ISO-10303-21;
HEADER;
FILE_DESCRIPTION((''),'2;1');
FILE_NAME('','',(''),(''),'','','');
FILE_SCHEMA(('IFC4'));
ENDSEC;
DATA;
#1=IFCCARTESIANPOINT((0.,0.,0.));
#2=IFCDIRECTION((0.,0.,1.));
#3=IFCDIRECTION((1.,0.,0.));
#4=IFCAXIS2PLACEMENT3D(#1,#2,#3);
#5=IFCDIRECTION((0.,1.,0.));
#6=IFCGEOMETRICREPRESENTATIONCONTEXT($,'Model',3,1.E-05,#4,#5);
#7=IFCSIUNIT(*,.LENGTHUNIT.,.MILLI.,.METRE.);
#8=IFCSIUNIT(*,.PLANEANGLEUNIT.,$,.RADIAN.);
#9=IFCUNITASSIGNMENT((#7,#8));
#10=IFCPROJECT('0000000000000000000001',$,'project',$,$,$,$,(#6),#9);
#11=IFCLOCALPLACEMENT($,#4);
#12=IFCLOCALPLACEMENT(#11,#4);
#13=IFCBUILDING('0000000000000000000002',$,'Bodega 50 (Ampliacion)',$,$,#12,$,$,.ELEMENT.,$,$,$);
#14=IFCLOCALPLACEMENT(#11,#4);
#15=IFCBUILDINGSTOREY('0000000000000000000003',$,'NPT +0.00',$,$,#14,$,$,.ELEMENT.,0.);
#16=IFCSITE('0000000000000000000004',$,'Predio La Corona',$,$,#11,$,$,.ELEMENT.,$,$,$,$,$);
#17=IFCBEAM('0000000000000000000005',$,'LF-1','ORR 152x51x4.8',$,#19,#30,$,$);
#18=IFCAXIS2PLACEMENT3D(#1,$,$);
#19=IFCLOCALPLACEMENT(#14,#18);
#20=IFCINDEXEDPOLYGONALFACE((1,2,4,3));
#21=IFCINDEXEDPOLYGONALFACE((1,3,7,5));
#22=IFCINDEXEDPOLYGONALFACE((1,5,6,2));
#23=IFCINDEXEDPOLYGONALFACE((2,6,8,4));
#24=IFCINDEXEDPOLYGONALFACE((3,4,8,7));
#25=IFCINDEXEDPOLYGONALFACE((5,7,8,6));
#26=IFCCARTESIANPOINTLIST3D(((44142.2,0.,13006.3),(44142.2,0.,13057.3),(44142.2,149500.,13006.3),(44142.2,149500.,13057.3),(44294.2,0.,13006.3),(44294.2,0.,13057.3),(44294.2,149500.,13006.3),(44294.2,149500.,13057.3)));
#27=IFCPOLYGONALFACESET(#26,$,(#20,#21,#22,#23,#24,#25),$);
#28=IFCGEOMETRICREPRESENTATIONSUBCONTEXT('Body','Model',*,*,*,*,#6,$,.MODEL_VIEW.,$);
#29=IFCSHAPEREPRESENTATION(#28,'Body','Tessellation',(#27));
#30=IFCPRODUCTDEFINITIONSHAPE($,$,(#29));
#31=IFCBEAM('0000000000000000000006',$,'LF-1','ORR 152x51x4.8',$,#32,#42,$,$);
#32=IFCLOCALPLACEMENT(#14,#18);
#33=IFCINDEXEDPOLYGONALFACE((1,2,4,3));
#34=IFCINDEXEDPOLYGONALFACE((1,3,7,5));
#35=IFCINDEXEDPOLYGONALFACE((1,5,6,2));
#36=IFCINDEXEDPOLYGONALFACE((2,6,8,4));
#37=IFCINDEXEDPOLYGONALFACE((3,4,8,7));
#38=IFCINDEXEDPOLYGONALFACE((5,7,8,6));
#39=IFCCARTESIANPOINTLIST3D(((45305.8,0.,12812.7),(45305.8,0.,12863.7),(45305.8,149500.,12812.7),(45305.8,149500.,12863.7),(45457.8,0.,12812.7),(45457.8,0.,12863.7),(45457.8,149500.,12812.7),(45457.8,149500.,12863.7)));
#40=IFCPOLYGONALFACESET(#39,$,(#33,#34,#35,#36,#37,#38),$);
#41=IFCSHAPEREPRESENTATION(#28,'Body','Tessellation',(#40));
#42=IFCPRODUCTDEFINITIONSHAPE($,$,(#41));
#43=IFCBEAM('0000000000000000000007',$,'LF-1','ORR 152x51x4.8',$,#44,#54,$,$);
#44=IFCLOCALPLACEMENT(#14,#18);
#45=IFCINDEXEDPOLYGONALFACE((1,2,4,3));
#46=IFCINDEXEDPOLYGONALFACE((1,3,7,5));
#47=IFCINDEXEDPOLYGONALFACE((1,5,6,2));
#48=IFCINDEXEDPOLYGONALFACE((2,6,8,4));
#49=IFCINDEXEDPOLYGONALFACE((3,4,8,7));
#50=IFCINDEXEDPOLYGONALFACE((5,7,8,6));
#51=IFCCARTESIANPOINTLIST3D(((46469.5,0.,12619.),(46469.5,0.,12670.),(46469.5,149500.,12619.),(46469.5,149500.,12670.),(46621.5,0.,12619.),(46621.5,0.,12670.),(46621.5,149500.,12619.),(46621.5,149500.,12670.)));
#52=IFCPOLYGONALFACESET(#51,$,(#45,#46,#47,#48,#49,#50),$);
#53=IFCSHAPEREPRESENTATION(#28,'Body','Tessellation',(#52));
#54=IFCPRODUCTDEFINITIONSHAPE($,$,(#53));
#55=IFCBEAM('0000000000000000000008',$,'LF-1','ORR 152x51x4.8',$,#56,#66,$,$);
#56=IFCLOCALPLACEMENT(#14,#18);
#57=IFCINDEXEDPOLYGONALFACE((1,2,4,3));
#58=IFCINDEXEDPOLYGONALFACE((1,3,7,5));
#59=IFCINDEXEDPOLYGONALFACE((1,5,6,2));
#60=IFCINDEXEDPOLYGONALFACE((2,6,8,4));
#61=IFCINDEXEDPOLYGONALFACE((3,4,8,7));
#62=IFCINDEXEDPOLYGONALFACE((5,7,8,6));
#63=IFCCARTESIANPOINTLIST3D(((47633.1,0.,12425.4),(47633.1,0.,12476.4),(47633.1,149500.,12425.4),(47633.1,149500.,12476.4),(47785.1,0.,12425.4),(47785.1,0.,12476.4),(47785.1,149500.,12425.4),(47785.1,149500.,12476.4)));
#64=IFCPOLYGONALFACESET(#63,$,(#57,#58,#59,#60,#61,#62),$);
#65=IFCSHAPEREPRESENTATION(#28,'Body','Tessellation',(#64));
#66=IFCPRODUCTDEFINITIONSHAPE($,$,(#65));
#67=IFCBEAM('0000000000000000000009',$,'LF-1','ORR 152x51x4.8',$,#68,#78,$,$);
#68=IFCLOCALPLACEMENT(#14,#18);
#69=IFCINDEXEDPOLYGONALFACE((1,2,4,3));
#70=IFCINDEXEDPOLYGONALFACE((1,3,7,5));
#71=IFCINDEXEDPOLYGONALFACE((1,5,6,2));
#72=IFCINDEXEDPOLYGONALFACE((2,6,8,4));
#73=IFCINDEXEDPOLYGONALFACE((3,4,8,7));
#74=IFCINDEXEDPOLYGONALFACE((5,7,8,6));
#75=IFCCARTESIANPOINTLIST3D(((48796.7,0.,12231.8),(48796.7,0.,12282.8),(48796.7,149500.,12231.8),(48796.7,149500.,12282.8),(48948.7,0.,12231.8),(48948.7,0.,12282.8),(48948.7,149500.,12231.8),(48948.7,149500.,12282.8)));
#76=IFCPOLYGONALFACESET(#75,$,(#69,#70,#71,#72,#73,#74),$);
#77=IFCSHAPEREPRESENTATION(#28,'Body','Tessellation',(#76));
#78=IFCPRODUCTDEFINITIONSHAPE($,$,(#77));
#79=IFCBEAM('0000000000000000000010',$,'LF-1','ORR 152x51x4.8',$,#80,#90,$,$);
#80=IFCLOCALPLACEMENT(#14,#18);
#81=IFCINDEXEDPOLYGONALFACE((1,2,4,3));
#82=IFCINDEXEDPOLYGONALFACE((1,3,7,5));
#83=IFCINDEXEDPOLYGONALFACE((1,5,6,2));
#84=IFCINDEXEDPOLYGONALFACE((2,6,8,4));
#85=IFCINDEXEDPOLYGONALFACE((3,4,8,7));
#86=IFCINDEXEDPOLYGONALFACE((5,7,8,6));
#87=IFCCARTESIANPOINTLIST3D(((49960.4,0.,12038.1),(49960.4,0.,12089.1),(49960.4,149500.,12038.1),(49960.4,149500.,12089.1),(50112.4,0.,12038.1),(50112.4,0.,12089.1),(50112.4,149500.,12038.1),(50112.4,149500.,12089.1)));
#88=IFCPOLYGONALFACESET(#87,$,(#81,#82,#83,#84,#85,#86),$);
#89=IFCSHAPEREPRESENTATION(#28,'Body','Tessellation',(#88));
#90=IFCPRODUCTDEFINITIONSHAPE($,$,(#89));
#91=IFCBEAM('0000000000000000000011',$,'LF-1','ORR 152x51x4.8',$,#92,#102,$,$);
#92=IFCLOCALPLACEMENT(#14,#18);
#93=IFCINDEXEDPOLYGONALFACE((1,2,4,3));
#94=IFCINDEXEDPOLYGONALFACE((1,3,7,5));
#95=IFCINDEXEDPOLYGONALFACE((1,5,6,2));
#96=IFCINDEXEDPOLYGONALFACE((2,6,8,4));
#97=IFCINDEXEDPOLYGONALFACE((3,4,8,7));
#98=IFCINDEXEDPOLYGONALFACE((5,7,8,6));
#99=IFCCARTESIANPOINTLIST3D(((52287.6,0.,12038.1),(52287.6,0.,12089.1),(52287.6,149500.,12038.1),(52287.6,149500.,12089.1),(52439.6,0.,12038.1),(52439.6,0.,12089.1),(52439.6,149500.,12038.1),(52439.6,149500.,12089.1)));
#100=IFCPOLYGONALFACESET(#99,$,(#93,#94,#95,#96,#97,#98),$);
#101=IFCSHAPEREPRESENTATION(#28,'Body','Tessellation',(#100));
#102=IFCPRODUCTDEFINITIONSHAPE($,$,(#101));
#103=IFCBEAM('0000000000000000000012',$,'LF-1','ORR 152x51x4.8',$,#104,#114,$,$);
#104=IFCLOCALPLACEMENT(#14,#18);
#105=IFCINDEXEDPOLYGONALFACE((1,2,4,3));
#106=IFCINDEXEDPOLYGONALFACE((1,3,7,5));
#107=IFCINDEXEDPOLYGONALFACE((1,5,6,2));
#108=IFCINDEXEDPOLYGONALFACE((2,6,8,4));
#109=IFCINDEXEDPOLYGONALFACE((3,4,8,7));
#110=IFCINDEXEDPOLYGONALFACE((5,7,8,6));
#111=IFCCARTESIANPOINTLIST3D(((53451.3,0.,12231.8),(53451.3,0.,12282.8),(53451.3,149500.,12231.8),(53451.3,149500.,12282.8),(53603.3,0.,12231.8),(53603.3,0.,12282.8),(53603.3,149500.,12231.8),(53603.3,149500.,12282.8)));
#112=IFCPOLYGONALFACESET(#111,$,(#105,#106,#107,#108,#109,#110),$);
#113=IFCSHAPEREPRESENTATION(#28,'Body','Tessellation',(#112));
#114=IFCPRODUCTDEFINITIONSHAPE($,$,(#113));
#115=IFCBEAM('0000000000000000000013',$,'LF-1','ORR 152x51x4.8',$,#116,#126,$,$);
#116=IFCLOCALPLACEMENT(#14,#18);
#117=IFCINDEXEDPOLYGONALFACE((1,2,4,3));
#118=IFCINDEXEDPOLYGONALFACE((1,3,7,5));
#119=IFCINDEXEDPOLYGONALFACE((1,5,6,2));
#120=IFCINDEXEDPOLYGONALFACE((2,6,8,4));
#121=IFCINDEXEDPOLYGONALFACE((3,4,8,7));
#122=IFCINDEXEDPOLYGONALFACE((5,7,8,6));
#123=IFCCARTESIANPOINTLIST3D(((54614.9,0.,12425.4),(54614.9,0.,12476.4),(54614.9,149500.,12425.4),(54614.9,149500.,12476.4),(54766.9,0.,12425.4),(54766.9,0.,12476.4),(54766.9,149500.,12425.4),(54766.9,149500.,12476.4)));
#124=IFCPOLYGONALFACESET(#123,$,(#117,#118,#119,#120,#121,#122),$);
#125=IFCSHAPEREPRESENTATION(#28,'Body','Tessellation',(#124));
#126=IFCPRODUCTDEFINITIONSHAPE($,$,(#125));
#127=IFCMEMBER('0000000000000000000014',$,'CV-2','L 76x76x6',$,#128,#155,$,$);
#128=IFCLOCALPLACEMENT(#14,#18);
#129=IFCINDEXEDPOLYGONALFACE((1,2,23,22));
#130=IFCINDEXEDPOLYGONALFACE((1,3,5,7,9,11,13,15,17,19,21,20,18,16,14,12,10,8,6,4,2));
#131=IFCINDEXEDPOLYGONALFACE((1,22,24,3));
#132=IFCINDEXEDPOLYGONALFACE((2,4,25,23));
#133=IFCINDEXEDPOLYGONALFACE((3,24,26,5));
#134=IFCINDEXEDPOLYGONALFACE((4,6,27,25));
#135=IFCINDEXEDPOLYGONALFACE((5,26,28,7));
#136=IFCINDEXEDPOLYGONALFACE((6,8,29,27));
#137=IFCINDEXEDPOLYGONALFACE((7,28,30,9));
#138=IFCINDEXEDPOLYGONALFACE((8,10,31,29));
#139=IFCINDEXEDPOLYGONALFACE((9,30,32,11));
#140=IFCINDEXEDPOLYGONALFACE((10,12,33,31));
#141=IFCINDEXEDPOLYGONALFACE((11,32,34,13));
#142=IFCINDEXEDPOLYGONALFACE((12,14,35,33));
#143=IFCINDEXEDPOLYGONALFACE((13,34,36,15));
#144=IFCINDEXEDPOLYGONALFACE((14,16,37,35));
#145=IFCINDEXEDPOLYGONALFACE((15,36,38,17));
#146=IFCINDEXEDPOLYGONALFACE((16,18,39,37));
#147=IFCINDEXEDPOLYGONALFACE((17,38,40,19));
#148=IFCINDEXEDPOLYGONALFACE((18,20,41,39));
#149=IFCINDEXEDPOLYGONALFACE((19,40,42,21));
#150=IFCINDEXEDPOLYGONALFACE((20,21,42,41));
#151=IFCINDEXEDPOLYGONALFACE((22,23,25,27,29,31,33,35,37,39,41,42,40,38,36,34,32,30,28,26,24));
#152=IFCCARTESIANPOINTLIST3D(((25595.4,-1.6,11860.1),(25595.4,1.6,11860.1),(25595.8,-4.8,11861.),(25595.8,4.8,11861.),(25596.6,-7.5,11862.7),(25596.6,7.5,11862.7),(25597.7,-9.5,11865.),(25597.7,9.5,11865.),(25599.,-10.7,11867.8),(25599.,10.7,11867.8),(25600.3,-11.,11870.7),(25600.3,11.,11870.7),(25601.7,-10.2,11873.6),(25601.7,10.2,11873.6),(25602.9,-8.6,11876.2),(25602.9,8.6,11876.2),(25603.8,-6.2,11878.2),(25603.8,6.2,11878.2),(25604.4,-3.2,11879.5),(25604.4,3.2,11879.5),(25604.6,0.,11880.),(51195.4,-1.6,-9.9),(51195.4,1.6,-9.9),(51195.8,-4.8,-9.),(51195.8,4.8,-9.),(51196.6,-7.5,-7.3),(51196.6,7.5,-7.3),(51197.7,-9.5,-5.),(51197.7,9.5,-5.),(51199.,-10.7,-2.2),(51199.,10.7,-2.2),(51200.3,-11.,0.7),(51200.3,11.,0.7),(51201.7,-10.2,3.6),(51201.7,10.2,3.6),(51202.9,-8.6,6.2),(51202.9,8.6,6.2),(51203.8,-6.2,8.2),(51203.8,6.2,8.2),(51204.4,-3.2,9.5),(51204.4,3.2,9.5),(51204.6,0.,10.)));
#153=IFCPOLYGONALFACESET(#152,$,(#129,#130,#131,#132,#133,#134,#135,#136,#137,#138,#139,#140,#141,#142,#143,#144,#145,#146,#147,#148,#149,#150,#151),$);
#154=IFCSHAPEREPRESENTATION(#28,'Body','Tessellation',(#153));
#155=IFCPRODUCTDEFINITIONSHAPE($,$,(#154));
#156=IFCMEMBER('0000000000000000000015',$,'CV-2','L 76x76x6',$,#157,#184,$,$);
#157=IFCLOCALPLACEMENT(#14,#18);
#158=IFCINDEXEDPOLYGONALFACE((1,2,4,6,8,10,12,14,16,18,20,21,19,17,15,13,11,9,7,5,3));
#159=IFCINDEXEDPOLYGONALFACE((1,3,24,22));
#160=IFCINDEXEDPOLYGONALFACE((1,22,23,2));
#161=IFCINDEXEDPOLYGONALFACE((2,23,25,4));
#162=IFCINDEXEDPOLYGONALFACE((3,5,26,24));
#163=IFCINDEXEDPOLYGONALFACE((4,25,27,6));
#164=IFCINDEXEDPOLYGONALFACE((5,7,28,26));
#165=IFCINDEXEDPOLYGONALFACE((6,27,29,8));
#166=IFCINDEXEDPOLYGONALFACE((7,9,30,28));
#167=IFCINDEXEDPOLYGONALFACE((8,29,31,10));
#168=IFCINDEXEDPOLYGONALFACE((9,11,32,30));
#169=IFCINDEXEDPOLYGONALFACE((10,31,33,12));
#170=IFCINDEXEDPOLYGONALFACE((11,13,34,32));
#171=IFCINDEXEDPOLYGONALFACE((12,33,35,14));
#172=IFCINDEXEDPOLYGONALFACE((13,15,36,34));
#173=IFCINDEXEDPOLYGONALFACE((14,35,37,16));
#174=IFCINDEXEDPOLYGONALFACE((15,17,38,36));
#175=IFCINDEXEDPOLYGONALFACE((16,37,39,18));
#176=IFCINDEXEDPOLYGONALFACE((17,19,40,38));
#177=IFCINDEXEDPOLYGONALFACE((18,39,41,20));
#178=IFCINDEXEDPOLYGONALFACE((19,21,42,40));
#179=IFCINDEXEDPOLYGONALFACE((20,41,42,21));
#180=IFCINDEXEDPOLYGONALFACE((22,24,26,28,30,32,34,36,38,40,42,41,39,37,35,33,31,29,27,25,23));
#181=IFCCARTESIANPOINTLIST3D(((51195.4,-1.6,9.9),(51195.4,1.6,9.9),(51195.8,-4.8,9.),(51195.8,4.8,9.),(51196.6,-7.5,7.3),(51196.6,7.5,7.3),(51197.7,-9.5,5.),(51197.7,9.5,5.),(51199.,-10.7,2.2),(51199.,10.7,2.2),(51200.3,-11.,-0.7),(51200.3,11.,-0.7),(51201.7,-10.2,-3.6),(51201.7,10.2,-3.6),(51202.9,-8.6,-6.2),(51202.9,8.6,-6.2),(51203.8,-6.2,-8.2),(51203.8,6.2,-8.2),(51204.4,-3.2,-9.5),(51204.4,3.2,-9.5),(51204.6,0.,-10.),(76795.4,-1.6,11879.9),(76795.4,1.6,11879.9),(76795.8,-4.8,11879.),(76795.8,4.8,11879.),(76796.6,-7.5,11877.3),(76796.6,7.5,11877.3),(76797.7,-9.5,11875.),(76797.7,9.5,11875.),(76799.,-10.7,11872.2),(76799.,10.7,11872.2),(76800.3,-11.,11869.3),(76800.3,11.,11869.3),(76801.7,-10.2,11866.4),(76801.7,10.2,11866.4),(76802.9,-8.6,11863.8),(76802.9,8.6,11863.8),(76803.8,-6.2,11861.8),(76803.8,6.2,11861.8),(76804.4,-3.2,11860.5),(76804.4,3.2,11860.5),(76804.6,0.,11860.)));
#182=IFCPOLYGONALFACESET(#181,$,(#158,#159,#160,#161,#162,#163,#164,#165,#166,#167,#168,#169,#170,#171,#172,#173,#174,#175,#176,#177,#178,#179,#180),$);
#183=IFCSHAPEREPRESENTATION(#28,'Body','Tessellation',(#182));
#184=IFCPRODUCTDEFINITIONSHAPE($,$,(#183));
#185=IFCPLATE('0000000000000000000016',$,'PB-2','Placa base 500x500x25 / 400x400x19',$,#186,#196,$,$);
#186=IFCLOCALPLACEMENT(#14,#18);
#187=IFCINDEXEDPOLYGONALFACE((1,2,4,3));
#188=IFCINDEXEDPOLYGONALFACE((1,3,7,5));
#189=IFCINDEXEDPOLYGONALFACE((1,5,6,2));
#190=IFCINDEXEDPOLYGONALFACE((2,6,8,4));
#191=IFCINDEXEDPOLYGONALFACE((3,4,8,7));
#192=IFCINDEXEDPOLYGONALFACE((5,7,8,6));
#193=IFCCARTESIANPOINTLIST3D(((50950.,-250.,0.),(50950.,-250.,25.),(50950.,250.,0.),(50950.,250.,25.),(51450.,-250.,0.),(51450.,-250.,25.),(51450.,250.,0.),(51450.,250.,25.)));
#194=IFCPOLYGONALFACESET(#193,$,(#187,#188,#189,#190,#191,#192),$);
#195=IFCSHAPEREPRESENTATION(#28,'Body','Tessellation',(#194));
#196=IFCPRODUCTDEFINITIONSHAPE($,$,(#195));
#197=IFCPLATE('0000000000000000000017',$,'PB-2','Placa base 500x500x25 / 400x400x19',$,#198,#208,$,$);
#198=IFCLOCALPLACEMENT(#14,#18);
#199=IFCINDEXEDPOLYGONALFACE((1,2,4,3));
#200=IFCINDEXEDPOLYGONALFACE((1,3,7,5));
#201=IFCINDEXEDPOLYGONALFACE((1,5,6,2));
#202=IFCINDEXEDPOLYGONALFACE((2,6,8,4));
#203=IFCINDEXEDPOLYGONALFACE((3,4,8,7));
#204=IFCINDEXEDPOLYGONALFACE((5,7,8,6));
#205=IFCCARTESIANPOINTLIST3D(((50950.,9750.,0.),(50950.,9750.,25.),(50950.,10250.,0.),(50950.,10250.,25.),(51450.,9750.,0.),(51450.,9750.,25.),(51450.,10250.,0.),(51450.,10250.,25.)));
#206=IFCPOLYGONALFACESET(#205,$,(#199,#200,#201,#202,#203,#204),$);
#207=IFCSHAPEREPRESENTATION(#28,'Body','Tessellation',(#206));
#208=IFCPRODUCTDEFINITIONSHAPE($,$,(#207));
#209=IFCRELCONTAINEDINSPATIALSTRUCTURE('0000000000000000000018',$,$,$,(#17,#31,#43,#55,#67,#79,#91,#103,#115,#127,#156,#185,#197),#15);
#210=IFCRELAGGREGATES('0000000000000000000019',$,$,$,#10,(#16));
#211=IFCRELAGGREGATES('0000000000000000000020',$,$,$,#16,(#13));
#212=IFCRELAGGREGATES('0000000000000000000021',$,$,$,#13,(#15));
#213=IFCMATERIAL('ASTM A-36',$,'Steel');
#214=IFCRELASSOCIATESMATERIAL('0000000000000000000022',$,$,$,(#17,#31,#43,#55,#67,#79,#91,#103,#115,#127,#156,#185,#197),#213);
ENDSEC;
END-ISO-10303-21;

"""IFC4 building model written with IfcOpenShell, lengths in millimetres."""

from ifc_helpers import new_model, si_unit, direction, frame, origin_with_axes, origin_2d, place, context, subcontext, project, spatial, rectangle, circle, extrude, material, element, save


model = new_model("IFC4")

# Units and contexts
model_context = context("Model", 3, precision=1e-05, world=origin_with_axes(), true_north=direction((0.0, 1.0, 0.0)))
body_context = subcontext(model_context, "Body", "Model", "MODEL_VIEW")
ifc_project = project(units=[si_unit("LENGTHUNIT", "METRE", prefix="MILLI"), si_unit("PLANEANGLEUNIT", "RADIAN")], contexts=[model_context])

# Site, building, storey
site_placement = place(None, origin_with_axes())
site = spatial("IfcSite", under=ifc_project, at=site_placement, Name="Predio La Corona", CompositionType="ELEMENT")
building_placement = place(site_placement, origin_with_axes())
building = spatial("IfcBuilding", under=site, at=building_placement, Name="Bodega 50 (Ampliacion)", CompositionType="ELEMENT")
storey_placement = place(site_placement, origin_with_axes())
storey = spatial("IfcBuildingStorey", under=building, at=storey_placement, Name="NPT +0.00", CompositionType="ELEMENT", Elevation=0.0)

# Shared definitions
ifc_material = material(Name="ASTM A-36", Category="Steel")

# Beams
for number, where, z_axis, x_axis, name in (
    (1, (44218.2, 0.0, 13031.8), (0.0, 1.0, 0.0), (0.0, 0.0, 1.0), "LF-1"),
    (2, (45381.8, 0.0, 12838.2), (0.0, 1.0, 0.0), (0.0, 0.0, 1.0), "LF-1"),
    (3, (46545.5, 0.0, 12644.5), (0.0, 1.0, 0.0), (0.0, 0.0, 1.0), "LF-1"),
    (4, (47709.1, 0.0, 12450.9), (0.0, 1.0, 0.0), (0.0, 0.0, 1.0), "LF-1"),
    (5, (48872.7, 0.0, 12257.3), (0.0, 1.0, 0.0), (0.0, 0.0, 1.0), "LF-1"),
    (6, (50036.4, 0.0, 12063.6), (0.0, 1.0, 0.0), (0.0, 0.0, 1.0), "LF-1"),
    (7, (52363.6, 0.0, 12063.6), (0.0, 1.0, 0.0), (0.0, 0.0, 1.0), "LF-1"),
    (8, (53527.3, 0.0, 12257.3), (0.0, 1.0, 0.0), (0.0, 0.0, 1.0), "LF-1"),
    (9, (54690.9, 0.0, 12450.9), (0.0, 1.0, 0.0), (0.0, 0.0, 1.0), "LF-1"),
):
    element("IfcBeam", number, at=place(storey_placement, frame(where, z_axis=z_axis, x_axis=x_axis)), inside=storey, material=ifc_material, Name=name, Description="ORR 152x51x4.8", context=body_context, shape_type="SweptSolid", body=[
        extrude(rectangle(XDim=51.0, YDim=152.0, at=origin_2d()), origin_with_axes(), (0.0, 0.0, 1.0), 149500.0),
    ])

# Members
for number, where, z_axis, x_axis, name in (
    (10, (51200.0, 0.0, 0.0), (-0.907222, 0.0, 0.420653), (0.420653, 0.0, 0.907222), "CV-2"),
    (11, (51200.0, 0.0, 0.0), (0.907222, 0.0, 0.420653), (0.420653, 0.0, -0.907222), "CV-2"),
):
    element("IfcMember", number, at=place(storey_placement, frame(where, z_axis=z_axis, x_axis=x_axis)), inside=storey, material=ifc_material, Name=name, Description="L 76x76x6", context=body_context, shape_type="SweptSolid", body=[
        extrude(circle(Radius=11.0, at=origin_2d()), origin_with_axes(), (0.0, 0.0, 1.0), 28218.0),
    ])

# Plates
for number, where, z_axis, x_axis, name in (
    (12, (51200.0, 0.0, 0.0), (0.0, 0.0, 1.0), (1.0, 0.0, 0.0), "PB-2"),
    (13, (51200.0, 10000.0, 0.0), (0.0, 0.0, 1.0), (1.0, 0.0, 0.0), "PB-2"),
):
    element("IfcPlate", number, at=place(storey_placement, frame(where, z_axis=z_axis, x_axis=x_axis)), inside=storey, material=ifc_material, Name=name, Description="Placa base 500x500x25 / 400x400x19", context=body_context, shape_type="SweptSolid", body=[
        extrude(rectangle(XDim=500.0, YDim=500.0, at=origin_2d()), origin_with_axes(), (0.0, 0.0, 1.0), 25.0),
    ])

save(model, "model.ifc")
